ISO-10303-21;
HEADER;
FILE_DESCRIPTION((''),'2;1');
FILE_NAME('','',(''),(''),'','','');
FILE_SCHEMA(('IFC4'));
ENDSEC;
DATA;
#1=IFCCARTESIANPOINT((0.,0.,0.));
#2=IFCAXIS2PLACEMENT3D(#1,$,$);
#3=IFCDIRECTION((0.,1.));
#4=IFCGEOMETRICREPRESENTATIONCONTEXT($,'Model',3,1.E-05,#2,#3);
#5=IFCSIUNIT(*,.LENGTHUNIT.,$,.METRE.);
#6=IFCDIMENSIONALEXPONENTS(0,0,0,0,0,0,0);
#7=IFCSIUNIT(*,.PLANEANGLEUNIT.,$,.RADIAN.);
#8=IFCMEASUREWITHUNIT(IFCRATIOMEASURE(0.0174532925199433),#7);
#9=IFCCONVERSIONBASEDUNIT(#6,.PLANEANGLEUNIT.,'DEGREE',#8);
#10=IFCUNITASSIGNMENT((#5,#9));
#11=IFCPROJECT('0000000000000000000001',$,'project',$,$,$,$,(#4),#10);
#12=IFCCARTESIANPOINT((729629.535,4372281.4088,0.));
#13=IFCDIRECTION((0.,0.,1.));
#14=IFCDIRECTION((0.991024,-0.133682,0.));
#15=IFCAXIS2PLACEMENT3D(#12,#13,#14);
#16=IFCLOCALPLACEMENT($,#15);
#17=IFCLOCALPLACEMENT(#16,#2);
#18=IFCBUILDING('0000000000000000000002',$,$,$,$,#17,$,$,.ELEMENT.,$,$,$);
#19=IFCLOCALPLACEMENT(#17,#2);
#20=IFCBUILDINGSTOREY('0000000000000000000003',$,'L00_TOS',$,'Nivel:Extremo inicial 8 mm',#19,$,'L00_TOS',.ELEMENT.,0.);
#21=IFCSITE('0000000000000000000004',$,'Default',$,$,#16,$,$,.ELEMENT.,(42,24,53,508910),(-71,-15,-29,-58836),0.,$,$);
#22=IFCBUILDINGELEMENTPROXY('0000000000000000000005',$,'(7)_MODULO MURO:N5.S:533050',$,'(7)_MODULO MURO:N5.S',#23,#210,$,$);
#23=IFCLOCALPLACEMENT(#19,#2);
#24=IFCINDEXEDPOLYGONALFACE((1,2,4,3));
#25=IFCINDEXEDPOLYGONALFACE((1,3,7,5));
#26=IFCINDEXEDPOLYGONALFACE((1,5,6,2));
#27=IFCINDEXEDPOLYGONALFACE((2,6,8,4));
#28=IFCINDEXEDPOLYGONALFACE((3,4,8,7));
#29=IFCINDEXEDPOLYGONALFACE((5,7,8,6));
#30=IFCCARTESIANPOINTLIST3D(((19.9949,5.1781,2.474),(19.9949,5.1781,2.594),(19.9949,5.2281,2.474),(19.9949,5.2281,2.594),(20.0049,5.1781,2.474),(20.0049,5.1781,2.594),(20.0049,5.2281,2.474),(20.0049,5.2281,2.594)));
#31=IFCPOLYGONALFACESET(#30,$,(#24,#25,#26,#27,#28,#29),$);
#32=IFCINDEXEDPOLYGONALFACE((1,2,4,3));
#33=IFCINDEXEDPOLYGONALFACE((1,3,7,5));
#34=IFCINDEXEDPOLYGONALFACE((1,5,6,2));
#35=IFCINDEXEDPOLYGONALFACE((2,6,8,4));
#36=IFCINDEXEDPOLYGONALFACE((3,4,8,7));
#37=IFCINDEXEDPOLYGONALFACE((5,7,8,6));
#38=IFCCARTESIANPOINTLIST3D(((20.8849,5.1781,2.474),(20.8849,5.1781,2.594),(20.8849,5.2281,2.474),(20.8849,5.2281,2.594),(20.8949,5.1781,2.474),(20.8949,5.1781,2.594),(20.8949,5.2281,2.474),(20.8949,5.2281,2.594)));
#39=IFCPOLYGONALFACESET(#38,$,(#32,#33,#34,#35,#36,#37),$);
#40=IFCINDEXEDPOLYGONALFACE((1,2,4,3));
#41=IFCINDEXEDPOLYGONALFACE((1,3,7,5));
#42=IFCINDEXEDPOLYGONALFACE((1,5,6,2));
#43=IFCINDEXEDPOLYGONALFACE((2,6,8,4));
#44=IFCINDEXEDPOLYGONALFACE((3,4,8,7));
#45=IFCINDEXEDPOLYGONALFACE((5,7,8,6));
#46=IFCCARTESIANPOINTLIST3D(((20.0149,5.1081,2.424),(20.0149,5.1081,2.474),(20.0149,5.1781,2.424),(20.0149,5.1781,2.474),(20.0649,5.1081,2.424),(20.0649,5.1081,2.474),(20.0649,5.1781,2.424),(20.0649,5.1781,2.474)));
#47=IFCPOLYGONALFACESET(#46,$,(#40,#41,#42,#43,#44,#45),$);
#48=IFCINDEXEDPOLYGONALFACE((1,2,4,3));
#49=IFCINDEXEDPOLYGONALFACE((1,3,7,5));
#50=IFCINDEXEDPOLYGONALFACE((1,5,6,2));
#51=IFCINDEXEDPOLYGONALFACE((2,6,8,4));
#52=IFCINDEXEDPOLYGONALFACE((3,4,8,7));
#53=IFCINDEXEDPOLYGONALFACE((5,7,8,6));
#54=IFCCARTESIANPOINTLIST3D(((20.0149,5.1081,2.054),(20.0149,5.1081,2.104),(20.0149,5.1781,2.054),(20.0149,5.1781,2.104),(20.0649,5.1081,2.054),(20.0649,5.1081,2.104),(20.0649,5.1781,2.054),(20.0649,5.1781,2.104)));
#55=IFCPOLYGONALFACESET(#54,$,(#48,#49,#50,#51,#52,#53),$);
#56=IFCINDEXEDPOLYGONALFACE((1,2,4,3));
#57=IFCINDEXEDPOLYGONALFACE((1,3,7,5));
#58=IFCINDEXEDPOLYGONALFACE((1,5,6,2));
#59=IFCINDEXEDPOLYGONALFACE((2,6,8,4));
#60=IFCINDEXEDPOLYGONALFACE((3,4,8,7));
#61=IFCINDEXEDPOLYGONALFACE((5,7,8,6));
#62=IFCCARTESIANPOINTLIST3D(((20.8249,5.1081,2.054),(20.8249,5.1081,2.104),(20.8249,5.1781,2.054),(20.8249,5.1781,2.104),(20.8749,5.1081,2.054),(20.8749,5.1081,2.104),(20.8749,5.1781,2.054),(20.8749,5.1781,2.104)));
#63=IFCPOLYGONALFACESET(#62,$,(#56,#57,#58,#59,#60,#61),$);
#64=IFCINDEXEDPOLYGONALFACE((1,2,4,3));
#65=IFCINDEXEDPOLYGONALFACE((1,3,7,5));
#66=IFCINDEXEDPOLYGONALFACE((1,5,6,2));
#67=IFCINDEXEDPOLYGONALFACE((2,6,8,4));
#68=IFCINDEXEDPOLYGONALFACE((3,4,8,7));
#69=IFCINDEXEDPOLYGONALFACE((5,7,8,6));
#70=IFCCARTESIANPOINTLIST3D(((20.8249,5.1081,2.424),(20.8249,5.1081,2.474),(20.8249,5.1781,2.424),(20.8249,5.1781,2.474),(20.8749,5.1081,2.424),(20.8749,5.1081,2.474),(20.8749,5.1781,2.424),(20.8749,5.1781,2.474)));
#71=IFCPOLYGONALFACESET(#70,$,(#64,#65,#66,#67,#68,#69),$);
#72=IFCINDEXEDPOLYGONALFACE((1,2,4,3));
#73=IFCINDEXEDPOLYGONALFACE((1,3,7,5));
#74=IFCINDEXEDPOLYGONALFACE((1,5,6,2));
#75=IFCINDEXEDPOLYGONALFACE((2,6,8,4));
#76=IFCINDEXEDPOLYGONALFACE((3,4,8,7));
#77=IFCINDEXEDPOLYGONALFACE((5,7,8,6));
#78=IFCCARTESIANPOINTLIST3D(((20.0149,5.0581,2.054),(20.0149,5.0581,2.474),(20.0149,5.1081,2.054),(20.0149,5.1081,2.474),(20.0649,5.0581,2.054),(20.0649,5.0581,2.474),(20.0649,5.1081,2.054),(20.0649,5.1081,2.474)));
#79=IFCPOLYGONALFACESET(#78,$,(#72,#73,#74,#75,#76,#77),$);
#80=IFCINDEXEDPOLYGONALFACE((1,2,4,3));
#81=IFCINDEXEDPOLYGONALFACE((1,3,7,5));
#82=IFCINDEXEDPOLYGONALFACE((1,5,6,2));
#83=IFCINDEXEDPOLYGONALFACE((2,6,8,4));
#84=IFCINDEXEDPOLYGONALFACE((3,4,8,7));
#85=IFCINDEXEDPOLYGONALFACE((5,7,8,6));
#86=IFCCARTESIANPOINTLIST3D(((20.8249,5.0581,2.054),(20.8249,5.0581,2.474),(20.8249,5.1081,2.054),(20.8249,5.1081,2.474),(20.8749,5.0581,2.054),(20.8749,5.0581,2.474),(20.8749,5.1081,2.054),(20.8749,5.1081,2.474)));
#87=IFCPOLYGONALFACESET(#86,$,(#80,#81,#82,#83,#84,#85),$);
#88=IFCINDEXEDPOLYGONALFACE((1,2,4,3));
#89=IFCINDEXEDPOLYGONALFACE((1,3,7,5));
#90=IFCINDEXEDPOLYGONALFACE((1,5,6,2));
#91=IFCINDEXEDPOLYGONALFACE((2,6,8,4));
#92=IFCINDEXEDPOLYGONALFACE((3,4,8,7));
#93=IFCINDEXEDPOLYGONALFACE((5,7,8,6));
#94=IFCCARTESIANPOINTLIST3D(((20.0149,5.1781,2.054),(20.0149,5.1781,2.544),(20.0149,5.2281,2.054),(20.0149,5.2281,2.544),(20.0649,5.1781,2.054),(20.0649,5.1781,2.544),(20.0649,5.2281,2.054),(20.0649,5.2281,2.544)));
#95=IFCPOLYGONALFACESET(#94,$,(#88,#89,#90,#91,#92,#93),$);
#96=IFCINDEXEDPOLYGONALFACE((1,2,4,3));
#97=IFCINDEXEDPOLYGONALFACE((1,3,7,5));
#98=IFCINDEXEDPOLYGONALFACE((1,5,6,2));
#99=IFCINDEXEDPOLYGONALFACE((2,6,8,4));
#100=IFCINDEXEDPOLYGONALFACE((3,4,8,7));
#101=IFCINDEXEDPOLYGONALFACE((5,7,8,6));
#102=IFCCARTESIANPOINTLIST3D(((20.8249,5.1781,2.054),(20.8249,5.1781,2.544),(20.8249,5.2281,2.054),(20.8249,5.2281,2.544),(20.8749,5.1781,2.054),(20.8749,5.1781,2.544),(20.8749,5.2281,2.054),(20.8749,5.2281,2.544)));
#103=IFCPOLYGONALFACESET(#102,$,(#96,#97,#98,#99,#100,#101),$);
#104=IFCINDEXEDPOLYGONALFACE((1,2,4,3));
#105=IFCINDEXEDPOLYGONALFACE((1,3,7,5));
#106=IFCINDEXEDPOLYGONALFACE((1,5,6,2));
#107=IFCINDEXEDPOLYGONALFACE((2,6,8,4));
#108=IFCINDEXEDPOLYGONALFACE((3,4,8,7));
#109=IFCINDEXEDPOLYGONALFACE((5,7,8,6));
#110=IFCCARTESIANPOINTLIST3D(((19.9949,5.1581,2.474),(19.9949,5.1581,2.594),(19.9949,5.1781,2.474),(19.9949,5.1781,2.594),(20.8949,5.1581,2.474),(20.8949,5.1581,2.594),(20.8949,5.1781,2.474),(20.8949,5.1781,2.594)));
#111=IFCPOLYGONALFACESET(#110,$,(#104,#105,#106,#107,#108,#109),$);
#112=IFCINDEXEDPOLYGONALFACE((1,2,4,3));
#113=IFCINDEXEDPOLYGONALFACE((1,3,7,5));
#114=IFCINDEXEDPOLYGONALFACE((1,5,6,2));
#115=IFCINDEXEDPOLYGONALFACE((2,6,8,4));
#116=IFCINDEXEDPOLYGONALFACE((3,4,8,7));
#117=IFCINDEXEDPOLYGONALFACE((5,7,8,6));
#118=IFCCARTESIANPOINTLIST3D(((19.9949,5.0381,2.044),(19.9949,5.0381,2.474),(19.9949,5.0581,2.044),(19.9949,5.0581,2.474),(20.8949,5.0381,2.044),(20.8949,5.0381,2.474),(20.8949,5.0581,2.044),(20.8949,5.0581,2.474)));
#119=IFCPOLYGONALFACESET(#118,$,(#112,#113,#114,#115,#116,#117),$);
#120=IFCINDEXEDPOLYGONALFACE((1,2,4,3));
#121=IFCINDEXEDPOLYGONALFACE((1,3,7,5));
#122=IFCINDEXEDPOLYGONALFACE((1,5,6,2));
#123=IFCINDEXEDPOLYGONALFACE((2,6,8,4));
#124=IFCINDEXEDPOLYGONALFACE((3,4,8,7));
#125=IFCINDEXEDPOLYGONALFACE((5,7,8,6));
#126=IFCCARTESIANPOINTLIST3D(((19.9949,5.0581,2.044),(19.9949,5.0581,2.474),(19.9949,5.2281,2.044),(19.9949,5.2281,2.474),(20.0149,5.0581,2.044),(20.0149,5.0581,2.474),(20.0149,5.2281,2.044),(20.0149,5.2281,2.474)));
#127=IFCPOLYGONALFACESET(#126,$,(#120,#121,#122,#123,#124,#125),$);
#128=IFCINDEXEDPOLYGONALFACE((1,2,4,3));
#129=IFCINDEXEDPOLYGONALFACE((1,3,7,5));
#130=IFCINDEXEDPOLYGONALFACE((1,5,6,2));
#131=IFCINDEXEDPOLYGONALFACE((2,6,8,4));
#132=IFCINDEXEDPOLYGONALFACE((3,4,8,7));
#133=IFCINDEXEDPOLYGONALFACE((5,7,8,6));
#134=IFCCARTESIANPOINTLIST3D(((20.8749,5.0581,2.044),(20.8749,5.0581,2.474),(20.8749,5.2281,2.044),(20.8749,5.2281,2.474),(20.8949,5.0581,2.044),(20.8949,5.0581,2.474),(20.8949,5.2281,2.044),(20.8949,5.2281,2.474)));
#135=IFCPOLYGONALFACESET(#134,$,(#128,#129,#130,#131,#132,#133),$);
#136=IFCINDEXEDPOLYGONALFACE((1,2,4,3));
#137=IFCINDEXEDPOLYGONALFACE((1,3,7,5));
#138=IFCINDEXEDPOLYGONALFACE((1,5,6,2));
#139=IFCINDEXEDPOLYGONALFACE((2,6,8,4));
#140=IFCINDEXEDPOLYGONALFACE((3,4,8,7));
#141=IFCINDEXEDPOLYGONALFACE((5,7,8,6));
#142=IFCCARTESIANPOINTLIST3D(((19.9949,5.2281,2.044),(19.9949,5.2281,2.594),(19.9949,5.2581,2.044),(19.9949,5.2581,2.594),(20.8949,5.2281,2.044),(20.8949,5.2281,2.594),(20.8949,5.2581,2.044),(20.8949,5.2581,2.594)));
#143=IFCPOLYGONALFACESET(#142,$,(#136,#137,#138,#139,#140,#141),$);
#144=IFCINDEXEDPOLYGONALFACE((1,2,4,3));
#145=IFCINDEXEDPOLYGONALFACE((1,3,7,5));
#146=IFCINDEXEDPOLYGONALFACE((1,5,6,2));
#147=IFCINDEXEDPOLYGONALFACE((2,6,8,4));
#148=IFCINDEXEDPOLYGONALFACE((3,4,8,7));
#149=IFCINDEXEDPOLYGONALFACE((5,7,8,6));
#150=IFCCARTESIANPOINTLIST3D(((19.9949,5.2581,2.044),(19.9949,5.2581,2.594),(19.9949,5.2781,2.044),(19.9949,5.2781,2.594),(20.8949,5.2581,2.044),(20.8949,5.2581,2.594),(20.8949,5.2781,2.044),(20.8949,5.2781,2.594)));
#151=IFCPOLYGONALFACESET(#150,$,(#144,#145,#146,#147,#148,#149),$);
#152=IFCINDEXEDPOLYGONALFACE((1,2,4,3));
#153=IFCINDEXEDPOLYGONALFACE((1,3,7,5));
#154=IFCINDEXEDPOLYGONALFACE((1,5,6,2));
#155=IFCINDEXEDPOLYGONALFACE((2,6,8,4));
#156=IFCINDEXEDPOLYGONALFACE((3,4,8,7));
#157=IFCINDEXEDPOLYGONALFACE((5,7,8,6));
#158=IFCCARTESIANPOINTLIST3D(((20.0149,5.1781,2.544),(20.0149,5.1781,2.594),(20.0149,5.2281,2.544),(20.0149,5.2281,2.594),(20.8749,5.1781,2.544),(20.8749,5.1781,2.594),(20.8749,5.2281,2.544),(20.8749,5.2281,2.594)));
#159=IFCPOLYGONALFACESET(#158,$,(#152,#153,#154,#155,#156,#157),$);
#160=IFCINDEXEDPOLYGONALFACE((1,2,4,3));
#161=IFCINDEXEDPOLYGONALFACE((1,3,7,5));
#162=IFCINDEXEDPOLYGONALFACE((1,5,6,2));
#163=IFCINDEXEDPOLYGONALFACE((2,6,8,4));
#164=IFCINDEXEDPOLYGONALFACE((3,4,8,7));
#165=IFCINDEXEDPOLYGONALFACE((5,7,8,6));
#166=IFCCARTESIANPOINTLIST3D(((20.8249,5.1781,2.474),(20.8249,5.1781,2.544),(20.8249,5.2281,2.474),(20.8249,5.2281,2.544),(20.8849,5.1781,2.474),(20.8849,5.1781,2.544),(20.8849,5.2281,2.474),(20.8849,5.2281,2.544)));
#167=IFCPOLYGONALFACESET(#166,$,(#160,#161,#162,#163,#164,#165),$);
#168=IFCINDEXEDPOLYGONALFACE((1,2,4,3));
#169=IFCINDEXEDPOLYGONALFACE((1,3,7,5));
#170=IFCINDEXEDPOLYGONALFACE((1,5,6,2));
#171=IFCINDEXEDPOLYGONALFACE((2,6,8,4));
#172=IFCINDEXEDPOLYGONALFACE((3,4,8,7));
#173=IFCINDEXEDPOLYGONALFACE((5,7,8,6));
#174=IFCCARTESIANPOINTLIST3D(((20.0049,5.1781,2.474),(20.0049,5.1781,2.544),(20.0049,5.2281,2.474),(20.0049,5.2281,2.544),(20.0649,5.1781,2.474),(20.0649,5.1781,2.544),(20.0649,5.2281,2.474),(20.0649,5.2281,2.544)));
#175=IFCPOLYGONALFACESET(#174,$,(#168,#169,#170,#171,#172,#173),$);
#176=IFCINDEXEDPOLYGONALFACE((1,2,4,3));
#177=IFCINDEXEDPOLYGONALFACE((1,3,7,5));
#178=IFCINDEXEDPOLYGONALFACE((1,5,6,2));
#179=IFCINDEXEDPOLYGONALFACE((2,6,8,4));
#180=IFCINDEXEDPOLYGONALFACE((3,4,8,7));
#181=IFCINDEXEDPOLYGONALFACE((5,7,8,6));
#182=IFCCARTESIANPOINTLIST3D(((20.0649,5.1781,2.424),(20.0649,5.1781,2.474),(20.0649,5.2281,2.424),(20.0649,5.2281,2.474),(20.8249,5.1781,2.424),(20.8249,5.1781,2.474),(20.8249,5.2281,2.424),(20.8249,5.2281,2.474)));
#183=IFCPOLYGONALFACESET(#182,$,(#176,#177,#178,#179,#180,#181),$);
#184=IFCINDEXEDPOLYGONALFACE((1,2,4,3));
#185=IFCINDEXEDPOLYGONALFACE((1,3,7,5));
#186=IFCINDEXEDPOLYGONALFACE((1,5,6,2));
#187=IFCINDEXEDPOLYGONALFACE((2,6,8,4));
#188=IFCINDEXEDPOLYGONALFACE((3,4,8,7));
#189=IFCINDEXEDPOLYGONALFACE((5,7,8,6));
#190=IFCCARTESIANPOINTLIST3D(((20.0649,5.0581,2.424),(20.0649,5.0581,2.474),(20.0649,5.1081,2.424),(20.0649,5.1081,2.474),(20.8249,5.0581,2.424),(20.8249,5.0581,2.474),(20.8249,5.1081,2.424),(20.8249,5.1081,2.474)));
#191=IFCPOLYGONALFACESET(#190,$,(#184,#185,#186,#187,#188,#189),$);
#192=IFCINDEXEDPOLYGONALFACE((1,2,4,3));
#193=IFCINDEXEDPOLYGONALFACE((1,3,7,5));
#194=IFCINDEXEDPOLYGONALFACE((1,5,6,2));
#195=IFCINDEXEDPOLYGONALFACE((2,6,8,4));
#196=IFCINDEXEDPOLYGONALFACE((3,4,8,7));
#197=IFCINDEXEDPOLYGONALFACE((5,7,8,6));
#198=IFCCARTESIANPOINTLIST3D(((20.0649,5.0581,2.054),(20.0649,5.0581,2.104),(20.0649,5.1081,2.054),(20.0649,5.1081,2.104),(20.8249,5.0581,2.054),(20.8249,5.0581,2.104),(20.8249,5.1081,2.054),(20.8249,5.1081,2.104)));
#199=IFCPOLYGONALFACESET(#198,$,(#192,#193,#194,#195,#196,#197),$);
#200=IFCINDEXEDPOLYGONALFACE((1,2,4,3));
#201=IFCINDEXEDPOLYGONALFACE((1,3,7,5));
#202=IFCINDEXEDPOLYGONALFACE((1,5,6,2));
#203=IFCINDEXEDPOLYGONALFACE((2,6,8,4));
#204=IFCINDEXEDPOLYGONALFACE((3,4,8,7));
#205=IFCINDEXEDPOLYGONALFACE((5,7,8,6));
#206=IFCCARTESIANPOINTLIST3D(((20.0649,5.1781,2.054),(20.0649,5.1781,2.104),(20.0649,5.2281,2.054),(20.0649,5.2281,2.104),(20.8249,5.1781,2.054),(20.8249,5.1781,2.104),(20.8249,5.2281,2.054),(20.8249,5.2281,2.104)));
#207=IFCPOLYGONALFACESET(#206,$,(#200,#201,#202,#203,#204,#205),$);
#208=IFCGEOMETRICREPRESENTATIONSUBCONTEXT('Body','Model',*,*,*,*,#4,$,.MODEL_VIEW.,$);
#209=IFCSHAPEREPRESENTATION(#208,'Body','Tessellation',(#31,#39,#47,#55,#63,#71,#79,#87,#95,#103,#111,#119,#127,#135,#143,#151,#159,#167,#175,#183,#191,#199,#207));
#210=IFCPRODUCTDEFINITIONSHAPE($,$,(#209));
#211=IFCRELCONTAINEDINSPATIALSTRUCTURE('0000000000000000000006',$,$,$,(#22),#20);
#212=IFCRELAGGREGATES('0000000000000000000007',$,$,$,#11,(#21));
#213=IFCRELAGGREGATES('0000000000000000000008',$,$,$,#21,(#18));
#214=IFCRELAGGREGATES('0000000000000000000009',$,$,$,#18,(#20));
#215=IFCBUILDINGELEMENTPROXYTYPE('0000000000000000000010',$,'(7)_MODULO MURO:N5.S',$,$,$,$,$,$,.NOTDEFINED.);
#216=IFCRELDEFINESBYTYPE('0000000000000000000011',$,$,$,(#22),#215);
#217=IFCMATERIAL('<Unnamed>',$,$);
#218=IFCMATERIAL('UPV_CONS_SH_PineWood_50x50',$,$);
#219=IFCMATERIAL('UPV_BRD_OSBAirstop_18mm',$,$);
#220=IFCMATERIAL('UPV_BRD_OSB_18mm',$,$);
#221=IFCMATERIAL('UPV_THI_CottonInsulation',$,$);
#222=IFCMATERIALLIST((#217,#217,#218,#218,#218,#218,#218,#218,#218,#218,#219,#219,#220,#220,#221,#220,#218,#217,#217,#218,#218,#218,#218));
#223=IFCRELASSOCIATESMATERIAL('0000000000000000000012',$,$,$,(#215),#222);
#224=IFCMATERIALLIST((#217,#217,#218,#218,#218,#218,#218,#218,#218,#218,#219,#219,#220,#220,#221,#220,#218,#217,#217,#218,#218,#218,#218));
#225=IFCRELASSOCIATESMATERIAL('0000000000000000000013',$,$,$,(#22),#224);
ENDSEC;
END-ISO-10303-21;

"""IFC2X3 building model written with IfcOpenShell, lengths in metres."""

from ifc_helpers import new_model, entity, si_unit, converted_unit, direction, frame, frame_2d, origin, origin_2d_with_axis, place, context, subcontext, project, spatial, rectangle, extrude, source, transform, mapped, material, material_list, type_object, type_shapes, element, save


model = new_model("IFC2X3")

# Units and contexts
model_context = context("Model", 3, precision=1e-05, world=origin(), true_north=direction((0.0, 1.0)))
body_context = subcontext(model_context, "Body", "Model", "MODEL_VIEW")
ifc_project = project(units=[si_unit("LENGTHUNIT", "METRE"), converted_unit("PLANEANGLEUNIT", "DEGREE", entity("IfcRatioMeasure", 0.0174532925199433), si_unit("PLANEANGLEUNIT", "RADIAN"), dimensions=[0, 0, 0, 0, 0, 0, 0])], contexts=[model_context])

# Site, building, storey
site_placement = place(None, frame((729629.535, 4372281.4088, 0.0), z_axis=(0.0, 0.0, 1.0), x_axis=(0.991024, -0.133682, 0.0)))
site = spatial("IfcSite", under=ifc_project, at=site_placement, Name="Default", CompositionType="ELEMENT", RefLatitude=(42, 24, 53, 508910), RefLongitude=(-71, -15, -29, -58836), RefElevation=0.0)
building_placement = place(site_placement, origin())
building = spatial("IfcBuilding", under=site, at=building_placement, CompositionType="ELEMENT")
storey_placement = place(building_placement, origin())
storey = spatial("IfcBuildingStorey", under=building, at=storey_placement, Name="L00_TOS", ObjectType="Nivel:Extremo inicial 8 mm", LongName="L00_TOS", CompositionType="ELEMENT", Elevation=0.0)

# Building element proxy
ifc_material_1 = material(Name="UPV_BRD_OSBAirstop_18mm")
ifc_material_2 = material(Name="UPV_BRD_OSB_18mm")
ifc_material_3 = material(Name="UPV_THI_CottonInsulation")
ifc_material_4 = material(Name="<Unnamed>")
ifc_material_5 = material(Name="UPV_CONS_SH_PineWood_50x50")
ifc_material_list_1 = material_list([ifc_material_4, ifc_material_4, ifc_material_5, ifc_material_5, ifc_material_5, ifc_material_5, ifc_material_5, ifc_material_5, ifc_material_5, ifc_material_5, ifc_material_1, ifc_material_1, ifc_material_2, ifc_material_2, ifc_material_3, ifc_material_2, ifc_material_5, ifc_material_4, ifc_material_4, ifc_material_5, ifc_material_5, ifc_material_5, ifc_material_5])
ifc_material_list_2 = material_list([ifc_material_4, ifc_material_4, ifc_material_5, ifc_material_5, ifc_material_5, ifc_material_5, ifc_material_5, ifc_material_5, ifc_material_5, ifc_material_5, ifc_material_1, ifc_material_1, ifc_material_2, ifc_material_2, ifc_material_3, ifc_material_2, ifc_material_5, ifc_material_4, ifc_material_4, ifc_material_5, ifc_material_5, ifc_material_5, ifc_material_5])
building_element_proxy_type_1 = type_object("IfcBuildingElementProxyType", Name="(7)_MODULO MURO:N5.S", PredefinedType="NOTDEFINED", material=ifc_material_list_2)
shared_shape_1 = source(origin(), body_context, "Body", "SweptSolid", [
    extrude(rectangle(XDim=0.01, YDim=0.05, at=frame_2d((0.0, 0.0), x_axis=(1.0, 0.0))), frame((-0.445, 0.025, 2.05), z_axis=(0.0, 0.0, 1.0), x_axis=(-1.0, 0.0, 0.0)), (0.0, 0.0, 1.0), 0.12),
    extrude(rectangle(XDim=0.01, YDim=0.05, at=frame_2d((0.0, 0.0), x_axis=(1.0, 0.0))), frame((0.445, 0.025, 2.05), z_axis=(0.0, 0.0, 1.0), x_axis=(-1.0, 0.0, 0.0)), (0.0, 0.0, 1.0), 0.12),
    extrude(rectangle(XDim=0.07, YDim=0.05, at=frame_2d((0.0, 0.0), x_axis=(1.0, 0.0))), frame((-0.405, -0.035, 2.0), z_axis=(0.0, 0.0, 1.0), x_axis=(0.0, 1.0, 0.0)), (0.0, 0.0, 1.0), 0.05),
    extrude(rectangle(XDim=0.07, YDim=0.05, at=frame_2d((0.0, 0.0), x_axis=(1.0, 0.0))), frame((-0.405, -0.035, 1.63), z_axis=(0.0, 0.0, 1.0), x_axis=(0.0, 1.0, 0.0)), (0.0, 0.0, 1.0), 0.05),
    extrude(rectangle(XDim=0.07, YDim=0.05, at=origin_2d_with_axis()), frame((0.405, -0.035, 1.63), z_axis=(0.0, 0.0, 1.0), x_axis=(0.0, 1.0, 0.0)), (0.0, 0.0, 1.0), 0.05),
    extrude(rectangle(XDim=0.07, YDim=0.05, at=frame_2d((0.0, 0.0), x_axis=(1.0, 0.0))), frame((0.405, -0.035, 2.0), z_axis=(0.0, 0.0, 1.0), x_axis=(0.0, 1.0, 0.0)), (0.0, 0.0, 1.0), 0.05),
    extrude(rectangle(XDim=0.05, YDim=0.05, at=origin_2d_with_axis()), frame((-0.405, -0.095, 1.63), z_axis=(0.0, 0.0, 1.0), x_axis=(0.0, -1.0, 0.0)), (0.0, 0.0, 1.0), 0.42),
    extrude(rectangle(XDim=0.05, YDim=0.05, at=origin_2d_with_axis()), frame((0.405, -0.095, 1.63), z_axis=(0.0, 0.0, 1.0), x_axis=(0.0, -1.0, 0.0)), (0.0, 0.0, 1.0), 0.42),
    extrude(rectangle(XDim=0.05, YDim=0.05, at=frame_2d((0.0, 0.0), x_axis=(1.0, 0.0))), frame((-0.405, 0.025, 1.63), z_axis=(0.0, 0.0, 1.0), x_axis=(0.0, -1.0, 0.0)), (0.0, 0.0, 1.0), 0.49),
    extrude(rectangle(XDim=0.05, YDim=0.05, at=origin_2d_with_axis()), frame((0.405, 0.025, 1.63), z_axis=(0.0, 0.0, 1.0), x_axis=(0.0, -1.0, 0.0)), (0.0, 0.0, 1.0), 0.49),
    extrude(rectangle(XDim=0.9, YDim=0.02, at=origin_2d_with_axis()), frame((0.0, -0.01, 2.05), z_axis=(0.0, 0.0, 1.0), x_axis=(-1.0, 0.0, 0.0)), (0.0, 0.0, 1.0), 0.12),
    extrude(rectangle(XDim=0.9, YDim=0.02, at=origin_2d_with_axis()), frame((0.0, -0.13, 1.62)), (0.0, 0.0, 1.0), 0.43),
    extrude(rectangle(XDim=0.17, YDim=0.02, at=frame_2d((0.0, 0.0), x_axis=(1.0, 0.0))), frame((-0.44, -0.035, 1.62), z_axis=(0.0, 0.0, 1.0), x_axis=(0.0, -1.0, 0.0)), (0.0, 0.0, 1.0), 0.43),
    extrude(rectangle(XDim=0.17, YDim=0.02, at=frame_2d((0.0, 0.0), x_axis=(1.0, 0.0))), frame((0.44, -0.035, 1.62), z_axis=(0.0, 0.0, 1.0), x_axis=(0.0, -1.0, 0.0)), (0.0, 0.0, 1.0), 0.43),
    extrude(rectangle(XDim=0.03, YDim=0.9, at=origin_2d_with_axis()), frame((0.0, 0.065, 1.62), z_axis=(0.0, 0.0, 1.0), x_axis=(0.0, 1.0, 0.0)), (0.0, 0.0, 1.0), 0.55),
    extrude(rectangle(XDim=0.02, YDim=0.9, at=origin_2d_with_axis()), frame((0.0, 0.09, 1.62), z_axis=(0.0, 0.0, 1.0), x_axis=(0.0, 1.0, 0.0)), (0.0, 0.0, 1.0), 0.55),
    extrude(rectangle(XDim=0.86, YDim=0.05, at=frame_2d((0.0, 0.0), x_axis=(1.0, 0.0))), frame((0.0, 0.025, 2.12), z_axis=(0.0, 0.0, 1.0), x_axis=(-1.0, 0.0, 0.0)), (0.0, 0.0, 1.0), 0.05),
    extrude(rectangle(XDim=0.05, YDim=0.06, at=frame_2d((0.0, 0.0), x_axis=(1.0, 0.0))), frame((0.41, 0.025, 2.05), z_axis=(0.0, 0.0, 1.0), x_axis=(0.0, -1.0, 0.0)), (0.0, 0.0, 1.0), 0.07),
    extrude(rectangle(XDim=0.06, YDim=0.05, at=frame_2d((0.0, 0.0), x_axis=(1.0, 0.0))), frame((-0.41, 0.025, 2.05)), (0.0, 0.0, 1.0), 0.07),
    extrude(rectangle(XDim=0.76, YDim=0.05, at=origin_2d_with_axis()), frame((0.0, 0.025, 2.0), z_axis=(0.0, 0.0, 1.0), x_axis=(-1.0, 0.0, 0.0)), (0.0, 0.0, 1.0), 0.05),
    extrude(rectangle(XDim=0.76, YDim=0.05, at=frame_2d((0.0, 0.0), x_axis=(1.0, 0.0))), frame((0.0, -0.095, 2.0), z_axis=(0.0, 0.0, 1.0), x_axis=(-1.0, 0.0, 0.0)), (0.0, 0.0, 1.0), 0.05),
    extrude(rectangle(XDim=0.76, YDim=0.05, at=frame_2d((0.0, 0.0), x_axis=(1.0, 0.0))), frame((0.0, -0.095, 1.63), z_axis=(0.0, 0.0, 1.0), x_axis=(-1.0, 0.0, 0.0)), (0.0, 0.0, 1.0), 0.05),
    extrude(rectangle(XDim=0.76, YDim=0.05, at=origin_2d_with_axis()), frame((0.0, 0.025, 1.63), z_axis=(0.0, 0.0, 1.0), x_axis=(-1.0, 0.0, 0.0)), (0.0, 0.0, 1.0), 0.05),
])
type_shapes(building_element_proxy_type_1, [shared_shape_1])
proxy_1_placement = place(storey_placement, frame((20.4449, 5.1781, 0.424)))
element("IfcBuildingElementProxy", 1, at=proxy_1_placement, inside=storey, type_object=building_element_proxy_type_1, material=ifc_material_list_1, Name="(7)_MODULO MURO:N5.S:533050", ObjectType="(7)_MODULO MURO:N5.S", context=body_context, shape_type="MappedRepresentation", body=[
    mapped(shared_shape_1, transform((0.0, 0.0, 0.0), scale=1.0)),
])

save(model, "model.ifc")
